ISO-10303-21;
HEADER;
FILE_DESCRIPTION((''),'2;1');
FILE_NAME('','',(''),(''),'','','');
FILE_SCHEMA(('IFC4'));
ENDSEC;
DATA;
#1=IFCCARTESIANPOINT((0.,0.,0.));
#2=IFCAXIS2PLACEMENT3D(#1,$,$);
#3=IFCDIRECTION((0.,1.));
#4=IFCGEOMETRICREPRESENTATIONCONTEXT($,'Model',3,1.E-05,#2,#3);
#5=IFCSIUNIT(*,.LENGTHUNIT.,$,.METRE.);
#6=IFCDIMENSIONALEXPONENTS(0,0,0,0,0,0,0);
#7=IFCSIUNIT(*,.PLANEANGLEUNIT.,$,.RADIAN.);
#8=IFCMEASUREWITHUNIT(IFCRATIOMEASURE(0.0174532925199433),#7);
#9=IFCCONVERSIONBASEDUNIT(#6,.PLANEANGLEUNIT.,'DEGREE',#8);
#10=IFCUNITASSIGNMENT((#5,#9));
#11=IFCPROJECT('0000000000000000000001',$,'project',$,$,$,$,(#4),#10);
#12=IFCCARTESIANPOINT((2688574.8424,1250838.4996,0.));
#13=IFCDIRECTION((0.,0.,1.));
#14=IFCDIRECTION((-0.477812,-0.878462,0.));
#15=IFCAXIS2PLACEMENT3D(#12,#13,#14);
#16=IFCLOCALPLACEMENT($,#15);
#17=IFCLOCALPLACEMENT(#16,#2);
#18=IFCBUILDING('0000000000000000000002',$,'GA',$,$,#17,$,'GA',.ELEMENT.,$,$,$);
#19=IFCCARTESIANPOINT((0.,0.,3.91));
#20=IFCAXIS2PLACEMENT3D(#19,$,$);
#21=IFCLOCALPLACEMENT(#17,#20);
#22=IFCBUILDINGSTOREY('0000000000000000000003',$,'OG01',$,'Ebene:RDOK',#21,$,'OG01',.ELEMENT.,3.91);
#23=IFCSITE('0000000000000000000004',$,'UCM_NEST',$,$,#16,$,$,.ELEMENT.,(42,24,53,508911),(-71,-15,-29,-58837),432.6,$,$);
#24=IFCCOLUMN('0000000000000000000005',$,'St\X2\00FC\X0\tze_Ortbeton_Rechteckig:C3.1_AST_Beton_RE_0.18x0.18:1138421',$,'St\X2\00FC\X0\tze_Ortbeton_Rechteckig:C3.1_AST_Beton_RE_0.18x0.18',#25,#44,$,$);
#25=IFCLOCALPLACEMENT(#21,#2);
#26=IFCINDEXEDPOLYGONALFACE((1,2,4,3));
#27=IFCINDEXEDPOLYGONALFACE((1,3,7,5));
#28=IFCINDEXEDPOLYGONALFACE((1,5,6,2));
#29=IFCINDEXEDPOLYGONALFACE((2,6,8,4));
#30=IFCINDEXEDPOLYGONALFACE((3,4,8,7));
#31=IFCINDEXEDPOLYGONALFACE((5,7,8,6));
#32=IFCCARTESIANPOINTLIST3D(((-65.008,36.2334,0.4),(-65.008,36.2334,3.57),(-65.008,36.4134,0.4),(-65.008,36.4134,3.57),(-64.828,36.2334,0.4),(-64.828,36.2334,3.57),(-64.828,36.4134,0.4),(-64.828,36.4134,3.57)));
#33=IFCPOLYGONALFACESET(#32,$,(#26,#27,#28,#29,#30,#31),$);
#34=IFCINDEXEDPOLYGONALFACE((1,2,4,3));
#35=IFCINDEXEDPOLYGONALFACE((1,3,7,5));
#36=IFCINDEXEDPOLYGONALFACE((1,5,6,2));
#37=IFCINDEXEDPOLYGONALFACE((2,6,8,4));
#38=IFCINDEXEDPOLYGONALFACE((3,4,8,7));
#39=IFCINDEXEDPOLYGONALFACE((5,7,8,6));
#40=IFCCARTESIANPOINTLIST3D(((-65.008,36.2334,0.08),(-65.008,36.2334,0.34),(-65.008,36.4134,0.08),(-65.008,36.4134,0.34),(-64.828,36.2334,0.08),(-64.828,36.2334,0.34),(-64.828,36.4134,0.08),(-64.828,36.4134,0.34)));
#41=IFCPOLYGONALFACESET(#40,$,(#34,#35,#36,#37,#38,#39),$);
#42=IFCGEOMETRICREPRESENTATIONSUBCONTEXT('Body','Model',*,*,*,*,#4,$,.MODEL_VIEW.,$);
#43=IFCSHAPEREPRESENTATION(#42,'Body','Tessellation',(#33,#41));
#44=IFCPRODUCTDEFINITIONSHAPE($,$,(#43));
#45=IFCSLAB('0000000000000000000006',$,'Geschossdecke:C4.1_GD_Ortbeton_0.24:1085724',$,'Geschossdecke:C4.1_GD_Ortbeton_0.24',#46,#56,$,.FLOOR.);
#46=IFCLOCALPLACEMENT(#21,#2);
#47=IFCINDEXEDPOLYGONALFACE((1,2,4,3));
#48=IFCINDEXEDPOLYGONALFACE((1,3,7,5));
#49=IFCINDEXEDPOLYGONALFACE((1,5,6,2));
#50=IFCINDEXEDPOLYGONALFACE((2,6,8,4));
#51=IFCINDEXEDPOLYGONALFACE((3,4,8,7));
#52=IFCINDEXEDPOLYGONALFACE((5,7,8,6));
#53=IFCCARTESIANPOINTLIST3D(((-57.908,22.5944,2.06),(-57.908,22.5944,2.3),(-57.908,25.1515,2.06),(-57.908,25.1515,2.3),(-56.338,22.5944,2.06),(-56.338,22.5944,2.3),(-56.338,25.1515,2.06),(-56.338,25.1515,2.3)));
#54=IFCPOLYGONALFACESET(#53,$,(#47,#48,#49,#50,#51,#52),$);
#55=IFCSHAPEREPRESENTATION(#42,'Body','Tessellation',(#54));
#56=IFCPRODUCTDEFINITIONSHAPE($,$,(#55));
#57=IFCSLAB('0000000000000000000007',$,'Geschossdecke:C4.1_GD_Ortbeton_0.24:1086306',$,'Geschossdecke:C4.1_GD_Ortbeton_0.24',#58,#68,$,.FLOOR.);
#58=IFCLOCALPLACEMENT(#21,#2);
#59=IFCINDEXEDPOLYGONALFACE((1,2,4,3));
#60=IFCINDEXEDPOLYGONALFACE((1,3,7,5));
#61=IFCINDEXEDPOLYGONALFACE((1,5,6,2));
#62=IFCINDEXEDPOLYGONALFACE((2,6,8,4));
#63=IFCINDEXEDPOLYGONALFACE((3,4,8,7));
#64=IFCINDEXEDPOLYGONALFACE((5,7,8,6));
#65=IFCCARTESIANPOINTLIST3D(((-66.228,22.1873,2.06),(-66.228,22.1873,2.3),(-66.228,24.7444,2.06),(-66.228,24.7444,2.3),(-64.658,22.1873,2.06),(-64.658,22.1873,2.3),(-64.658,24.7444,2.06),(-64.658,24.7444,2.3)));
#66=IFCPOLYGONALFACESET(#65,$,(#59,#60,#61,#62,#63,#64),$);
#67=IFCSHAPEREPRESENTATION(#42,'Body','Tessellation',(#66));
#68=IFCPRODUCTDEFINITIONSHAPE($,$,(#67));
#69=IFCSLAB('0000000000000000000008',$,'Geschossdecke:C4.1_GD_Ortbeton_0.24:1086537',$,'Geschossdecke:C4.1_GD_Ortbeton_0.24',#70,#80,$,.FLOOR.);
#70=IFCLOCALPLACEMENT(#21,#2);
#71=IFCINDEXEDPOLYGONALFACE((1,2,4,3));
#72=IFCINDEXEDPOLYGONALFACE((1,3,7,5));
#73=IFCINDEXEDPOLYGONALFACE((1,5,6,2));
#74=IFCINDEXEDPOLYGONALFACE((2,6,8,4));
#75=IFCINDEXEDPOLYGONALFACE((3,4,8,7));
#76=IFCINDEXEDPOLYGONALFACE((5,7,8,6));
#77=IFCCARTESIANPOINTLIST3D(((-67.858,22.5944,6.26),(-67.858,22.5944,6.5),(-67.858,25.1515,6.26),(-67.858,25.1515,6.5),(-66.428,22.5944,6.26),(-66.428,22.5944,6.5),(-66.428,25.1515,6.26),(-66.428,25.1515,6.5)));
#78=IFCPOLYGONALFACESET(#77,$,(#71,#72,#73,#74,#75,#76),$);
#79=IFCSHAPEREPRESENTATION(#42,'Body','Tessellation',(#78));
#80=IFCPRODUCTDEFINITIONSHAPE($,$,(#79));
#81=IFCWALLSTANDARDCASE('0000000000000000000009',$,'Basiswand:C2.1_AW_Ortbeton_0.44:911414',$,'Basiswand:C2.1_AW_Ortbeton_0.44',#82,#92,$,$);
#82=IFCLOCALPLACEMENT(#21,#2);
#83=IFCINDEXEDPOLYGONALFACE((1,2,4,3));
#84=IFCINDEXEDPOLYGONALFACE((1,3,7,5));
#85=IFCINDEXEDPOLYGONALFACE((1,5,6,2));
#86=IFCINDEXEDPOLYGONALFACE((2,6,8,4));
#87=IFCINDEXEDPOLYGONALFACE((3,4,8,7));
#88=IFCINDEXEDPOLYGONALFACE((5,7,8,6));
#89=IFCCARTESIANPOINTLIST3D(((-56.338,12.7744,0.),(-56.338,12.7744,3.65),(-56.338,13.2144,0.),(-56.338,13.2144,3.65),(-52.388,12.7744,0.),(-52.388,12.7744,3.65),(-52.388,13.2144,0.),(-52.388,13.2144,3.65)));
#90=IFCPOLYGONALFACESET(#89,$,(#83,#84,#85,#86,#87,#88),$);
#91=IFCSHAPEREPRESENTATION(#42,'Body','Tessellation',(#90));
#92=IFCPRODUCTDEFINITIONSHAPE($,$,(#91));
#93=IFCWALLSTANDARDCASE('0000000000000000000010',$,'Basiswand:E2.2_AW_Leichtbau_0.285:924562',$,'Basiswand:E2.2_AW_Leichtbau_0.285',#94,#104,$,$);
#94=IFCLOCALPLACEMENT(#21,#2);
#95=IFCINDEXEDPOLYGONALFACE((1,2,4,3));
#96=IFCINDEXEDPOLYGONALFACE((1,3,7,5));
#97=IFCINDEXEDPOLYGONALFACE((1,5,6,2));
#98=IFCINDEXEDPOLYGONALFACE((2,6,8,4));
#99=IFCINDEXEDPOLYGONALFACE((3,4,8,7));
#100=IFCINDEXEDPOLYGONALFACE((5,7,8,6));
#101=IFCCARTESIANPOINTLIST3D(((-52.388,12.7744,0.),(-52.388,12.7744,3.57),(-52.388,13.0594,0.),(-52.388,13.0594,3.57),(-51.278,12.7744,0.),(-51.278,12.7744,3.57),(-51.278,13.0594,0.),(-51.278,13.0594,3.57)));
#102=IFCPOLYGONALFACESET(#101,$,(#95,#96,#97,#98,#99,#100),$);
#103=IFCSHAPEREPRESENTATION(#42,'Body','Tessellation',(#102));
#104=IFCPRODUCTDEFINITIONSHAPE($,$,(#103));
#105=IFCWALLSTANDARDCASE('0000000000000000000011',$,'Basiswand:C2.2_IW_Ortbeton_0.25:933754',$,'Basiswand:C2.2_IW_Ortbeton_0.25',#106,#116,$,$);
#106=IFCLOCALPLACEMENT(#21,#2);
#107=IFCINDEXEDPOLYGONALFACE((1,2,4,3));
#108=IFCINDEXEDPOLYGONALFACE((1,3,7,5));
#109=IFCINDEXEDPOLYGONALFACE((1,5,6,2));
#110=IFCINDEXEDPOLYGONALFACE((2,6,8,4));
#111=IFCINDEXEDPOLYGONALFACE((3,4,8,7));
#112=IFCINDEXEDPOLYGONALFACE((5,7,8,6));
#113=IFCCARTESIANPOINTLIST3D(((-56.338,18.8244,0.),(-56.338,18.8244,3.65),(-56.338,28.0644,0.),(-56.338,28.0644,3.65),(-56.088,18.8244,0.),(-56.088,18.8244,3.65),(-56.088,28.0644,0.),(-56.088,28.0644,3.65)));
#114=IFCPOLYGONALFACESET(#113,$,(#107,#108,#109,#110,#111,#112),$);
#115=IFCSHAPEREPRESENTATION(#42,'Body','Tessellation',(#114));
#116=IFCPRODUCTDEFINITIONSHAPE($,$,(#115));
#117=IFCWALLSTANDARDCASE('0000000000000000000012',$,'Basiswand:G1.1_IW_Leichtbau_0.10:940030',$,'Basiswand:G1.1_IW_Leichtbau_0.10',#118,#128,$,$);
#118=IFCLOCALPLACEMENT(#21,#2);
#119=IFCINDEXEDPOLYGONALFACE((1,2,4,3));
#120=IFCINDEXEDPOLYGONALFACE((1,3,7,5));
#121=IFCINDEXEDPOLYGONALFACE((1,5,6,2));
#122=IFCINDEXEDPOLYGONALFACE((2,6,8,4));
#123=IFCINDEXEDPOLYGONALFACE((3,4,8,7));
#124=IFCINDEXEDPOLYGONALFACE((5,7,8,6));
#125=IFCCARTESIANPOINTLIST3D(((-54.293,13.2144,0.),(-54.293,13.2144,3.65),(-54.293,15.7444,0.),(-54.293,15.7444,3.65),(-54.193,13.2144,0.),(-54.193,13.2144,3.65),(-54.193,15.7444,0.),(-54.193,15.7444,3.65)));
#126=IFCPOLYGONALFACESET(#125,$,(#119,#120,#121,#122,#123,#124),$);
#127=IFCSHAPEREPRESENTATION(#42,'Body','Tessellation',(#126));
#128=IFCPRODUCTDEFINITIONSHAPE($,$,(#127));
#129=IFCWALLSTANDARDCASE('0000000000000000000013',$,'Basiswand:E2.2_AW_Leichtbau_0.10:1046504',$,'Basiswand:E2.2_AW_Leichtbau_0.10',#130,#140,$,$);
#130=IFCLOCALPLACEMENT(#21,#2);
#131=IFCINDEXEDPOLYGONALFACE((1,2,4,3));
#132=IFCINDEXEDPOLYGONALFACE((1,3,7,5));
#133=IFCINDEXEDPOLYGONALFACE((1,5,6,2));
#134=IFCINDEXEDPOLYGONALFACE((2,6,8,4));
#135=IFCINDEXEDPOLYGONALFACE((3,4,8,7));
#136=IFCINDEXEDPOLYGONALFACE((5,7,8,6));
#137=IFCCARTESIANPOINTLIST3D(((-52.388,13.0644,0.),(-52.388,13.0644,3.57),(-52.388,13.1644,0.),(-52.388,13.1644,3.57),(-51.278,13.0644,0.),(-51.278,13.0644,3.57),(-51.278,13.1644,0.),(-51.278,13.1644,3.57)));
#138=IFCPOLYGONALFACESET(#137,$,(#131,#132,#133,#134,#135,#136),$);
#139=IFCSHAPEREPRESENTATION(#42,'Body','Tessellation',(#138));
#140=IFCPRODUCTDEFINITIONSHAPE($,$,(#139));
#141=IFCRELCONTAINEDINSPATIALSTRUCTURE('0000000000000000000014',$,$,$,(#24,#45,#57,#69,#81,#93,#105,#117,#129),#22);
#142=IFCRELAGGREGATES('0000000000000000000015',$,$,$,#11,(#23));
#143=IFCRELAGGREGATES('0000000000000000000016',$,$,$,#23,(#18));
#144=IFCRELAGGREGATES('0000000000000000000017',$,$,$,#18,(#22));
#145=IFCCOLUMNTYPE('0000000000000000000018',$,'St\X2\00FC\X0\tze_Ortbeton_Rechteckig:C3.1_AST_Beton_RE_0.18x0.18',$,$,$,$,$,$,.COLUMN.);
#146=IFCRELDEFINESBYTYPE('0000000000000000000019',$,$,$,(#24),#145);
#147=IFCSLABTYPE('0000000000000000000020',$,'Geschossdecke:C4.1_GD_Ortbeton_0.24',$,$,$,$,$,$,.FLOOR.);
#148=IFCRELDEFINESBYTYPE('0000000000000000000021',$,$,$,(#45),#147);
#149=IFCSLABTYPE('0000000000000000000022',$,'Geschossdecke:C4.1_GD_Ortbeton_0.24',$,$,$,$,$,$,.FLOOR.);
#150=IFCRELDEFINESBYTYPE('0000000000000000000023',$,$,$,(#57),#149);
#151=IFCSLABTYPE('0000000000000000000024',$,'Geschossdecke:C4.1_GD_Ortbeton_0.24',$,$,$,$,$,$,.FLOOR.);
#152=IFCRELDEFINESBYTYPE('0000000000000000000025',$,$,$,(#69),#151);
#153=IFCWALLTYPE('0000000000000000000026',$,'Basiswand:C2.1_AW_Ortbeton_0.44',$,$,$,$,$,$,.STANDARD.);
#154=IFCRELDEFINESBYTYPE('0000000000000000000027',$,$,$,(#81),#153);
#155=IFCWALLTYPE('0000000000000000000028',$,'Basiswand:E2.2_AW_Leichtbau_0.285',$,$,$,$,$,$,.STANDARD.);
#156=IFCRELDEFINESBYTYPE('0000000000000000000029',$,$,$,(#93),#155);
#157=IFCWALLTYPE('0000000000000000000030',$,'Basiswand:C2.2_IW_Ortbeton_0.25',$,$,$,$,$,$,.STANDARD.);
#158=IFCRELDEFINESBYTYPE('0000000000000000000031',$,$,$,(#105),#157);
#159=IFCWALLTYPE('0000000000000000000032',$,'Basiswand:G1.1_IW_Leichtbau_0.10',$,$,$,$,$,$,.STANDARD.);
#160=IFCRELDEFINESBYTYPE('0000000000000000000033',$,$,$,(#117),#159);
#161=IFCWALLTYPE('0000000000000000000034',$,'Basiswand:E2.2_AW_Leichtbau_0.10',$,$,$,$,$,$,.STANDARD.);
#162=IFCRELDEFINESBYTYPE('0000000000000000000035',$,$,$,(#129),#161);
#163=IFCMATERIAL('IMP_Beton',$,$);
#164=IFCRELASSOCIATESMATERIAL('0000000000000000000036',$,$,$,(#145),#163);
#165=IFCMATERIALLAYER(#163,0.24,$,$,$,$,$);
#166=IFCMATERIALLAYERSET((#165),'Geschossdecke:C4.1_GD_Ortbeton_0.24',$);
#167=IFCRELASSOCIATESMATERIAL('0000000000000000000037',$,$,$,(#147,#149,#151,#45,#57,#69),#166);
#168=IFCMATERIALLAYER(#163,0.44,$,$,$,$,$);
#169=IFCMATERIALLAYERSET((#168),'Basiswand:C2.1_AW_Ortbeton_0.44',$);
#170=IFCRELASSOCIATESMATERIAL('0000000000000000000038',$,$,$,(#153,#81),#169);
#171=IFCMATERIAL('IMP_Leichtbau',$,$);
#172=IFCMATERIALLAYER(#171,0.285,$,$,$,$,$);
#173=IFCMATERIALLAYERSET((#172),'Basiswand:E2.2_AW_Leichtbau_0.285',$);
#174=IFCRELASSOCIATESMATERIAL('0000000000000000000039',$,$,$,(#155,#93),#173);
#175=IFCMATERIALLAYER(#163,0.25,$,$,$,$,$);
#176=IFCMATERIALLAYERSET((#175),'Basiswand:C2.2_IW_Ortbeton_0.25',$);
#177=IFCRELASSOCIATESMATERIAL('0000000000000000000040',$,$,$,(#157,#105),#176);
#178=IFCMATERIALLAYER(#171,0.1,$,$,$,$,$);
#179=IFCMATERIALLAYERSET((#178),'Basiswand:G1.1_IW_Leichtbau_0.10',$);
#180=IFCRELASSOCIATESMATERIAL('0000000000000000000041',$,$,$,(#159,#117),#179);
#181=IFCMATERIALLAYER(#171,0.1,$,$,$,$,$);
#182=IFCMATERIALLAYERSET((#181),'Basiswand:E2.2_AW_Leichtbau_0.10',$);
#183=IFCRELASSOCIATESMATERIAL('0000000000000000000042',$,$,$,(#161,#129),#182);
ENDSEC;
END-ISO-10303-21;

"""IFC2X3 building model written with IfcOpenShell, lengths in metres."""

from ifc_helpers import new_model, entity, si_unit, converted_unit, direction, frame, frame_2d, origin, origin_2d_with_axis, place, context, subcontext, project, spatial, polyline, rectangle, extrude, clip, bounded_halfspace, source, transform, mapped, material, layer, layer_set, layer_usage, type_object, type_shapes, element, save


model = new_model("IFC2X3")

# Units and contexts
model_context = context("Model", 3, precision=1e-05, world=origin(), true_north=direction((0.0, 1.0)))
body_context = subcontext(model_context, "Body", "Model", "MODEL_VIEW")
ifc_project = project(units=[si_unit("LENGTHUNIT", "METRE"), converted_unit("PLANEANGLEUNIT", "DEGREE", entity("IfcRatioMeasure", 0.0174532925199433), si_unit("PLANEANGLEUNIT", "RADIAN"), dimensions=[0, 0, 0, 0, 0, 0, 0])], contexts=[model_context])

# Site, building, storey
site_placement = place(None, frame((2688574.8424, 1250838.4996, 0.0), z_axis=(0.0, 0.0, 1.0), x_axis=(-0.477812, -0.878462, 0.0)))
site = spatial("IfcSite", under=ifc_project, at=site_placement, Name="UCM_NEST", CompositionType="ELEMENT", RefLatitude=(42, 24, 53, 508911), RefLongitude=(-71, -15, -29, -58837), RefElevation=432.6)
building_placement = place(site_placement, origin())
building = spatial("IfcBuilding", under=site, at=building_placement, Name="GA", LongName="GA", CompositionType="ELEMENT")
storey_placement = place(building_placement, frame((0.0, 0.0, 3.91)))
storey = spatial("IfcBuildingStorey", under=building, at=storey_placement, Name="OG01", ObjectType="Ebene:RDOK", LongName="OG01", CompositionType="ELEMENT", Elevation=3.91)

# Column
ifc_material_1 = material(Name="IMP_Beton")
column_type_1 = type_object("IfcColumnType", Name="Stütze_Ortbeton_Rechteckig:C3.1_AST_Beton_RE_0.18x0.18", PredefinedType="COLUMN", material=ifc_material_1)
shared_shape_1 = source(origin(), body_context, "Body", "SweptSolid", [
    extrude(rectangle(XDim=0.18, YDim=0.18, at=origin_2d_with_axis()), frame((-64.918, 36.3234, 4.31), z_axis=(0.0, 0.0, 1.0), x_axis=(0.0, -1.0, 0.0)), (0.0, 0.0, 1.0), 3.17),
    extrude(rectangle(XDim=0.18, YDim=0.18, at=origin_2d_with_axis()), frame((-64.918, 36.3234, 3.99), z_axis=(0.0, 0.0, 1.0), x_axis=(0.0, -1.0, 0.0)), (0.0, 0.0, 1.0), 0.26),
])
type_shapes(column_type_1, [shared_shape_1])
column_1_placement = place(storey_placement, frame((0.0, 0.0, -3.91)))
element("IfcColumn", 1, at=column_1_placement, inside=storey, type_object=column_type_1, Name="Stütze_Ortbeton_Rechteckig:C3.1_AST_Beton_RE_0.18x0.18:1138421", ObjectType="Stütze_Ortbeton_Rechteckig:C3.1_AST_Beton_RE_0.18x0.18", context=body_context, shape_type="MappedRepresentation", body=[
    mapped(shared_shape_1, transform((0.0, 0.0, 0.0), scale=1.0)),
])

# Slabs
ifc_layer_1 = layer(ifc_material_1, 0.24)
ifc_layer_set_1 = layer_set([ifc_layer_1], Name="Geschossdecke:C4.1_GD_Ortbeton_0.24")
ifc_layer_usage_1 = layer_usage(ifc_layer_set_1, "AXIS3", "POSITIVE", 0.0)
slab_type_1 = type_object("IfcSlabType", Name="Geschossdecke:C4.1_GD_Ortbeton_0.24", PredefinedType="FLOOR", material=ifc_layer_set_1)
slab_1_placement = place(storey_placement, origin())
element("IfcSlab", 2, at=slab_1_placement, inside=storey, type_object=slab_type_1, material=ifc_layer_usage_1, Name="Geschossdecke:C4.1_GD_Ortbeton_0.24:1085724", ObjectType="Geschossdecke:C4.1_GD_Ortbeton_0.24", PredefinedType="FLOOR", context=body_context, shape_type="SweptSolid", body=[
    extrude(rectangle(XDim=2.5571, YDim=1.57, at=frame_2d((0.0, 0.0), x_axis=(1.0, 0.0))), frame((-57.123, 23.873, 2.3), z_axis=(0.0, 0.0, -1.0), x_axis=(0.0, 1.0, 0.0)), (0.0, 0.0, 1.0), 0.24),
])
ifc_layer_usage_2 = layer_usage(ifc_layer_set_1, "AXIS3", "POSITIVE", 0.0)
slab_type_2 = type_object("IfcSlabType", Name="Geschossdecke:C4.1_GD_Ortbeton_0.24", PredefinedType="FLOOR", material=ifc_layer_set_1)
slab_2_placement = place(storey_placement, origin())
element("IfcSlab", 3, at=slab_2_placement, inside=storey, type_object=slab_type_2, material=ifc_layer_usage_2, Name="Geschossdecke:C4.1_GD_Ortbeton_0.24:1086306", ObjectType="Geschossdecke:C4.1_GD_Ortbeton_0.24", PredefinedType="FLOOR", context=body_context, shape_type="SweptSolid", body=[
    extrude(rectangle(XDim=2.5571, YDim=1.57, at=frame_2d((0.0, 0.0), x_axis=(1.0, 0.0))), frame((-65.443, 23.4659, 2.3), z_axis=(0.0, 0.0, -1.0), x_axis=(0.0, 1.0, 0.0)), (0.0, 0.0, 1.0), 0.24),
])
ifc_layer_usage_3 = layer_usage(ifc_layer_set_1, "AXIS3", "POSITIVE", 0.0)
slab_type_3 = type_object("IfcSlabType", Name="Geschossdecke:C4.1_GD_Ortbeton_0.24", PredefinedType="FLOOR", material=ifc_layer_set_1)
slab_3_placement = place(storey_placement, origin())
element("IfcSlab", 4, at=slab_3_placement, inside=storey, type_object=slab_type_3, material=ifc_layer_usage_3, Name="Geschossdecke:C4.1_GD_Ortbeton_0.24:1086537", ObjectType="Geschossdecke:C4.1_GD_Ortbeton_0.24", PredefinedType="FLOOR", context=body_context, shape_type="SweptSolid", body=[
    extrude(rectangle(XDim=2.5571, YDim=1.43, at=frame_2d((0.0, 0.0), x_axis=(1.0, 0.0))), frame((-67.143, 23.873, 6.5), z_axis=(0.0, 0.0, -1.0), x_axis=(0.0, 1.0, 0.0)), (0.0, 0.0, 1.0), 0.24),
])

# Walls
ifc_layer_2 = layer(ifc_material_1, 0.44)
ifc_layer_set_2 = layer_set([ifc_layer_2], Name="Basiswand:C2.1_AW_Ortbeton_0.44")
ifc_layer_usage_4 = layer_usage(ifc_layer_set_2, "AXIS2", "NEGATIVE", 0.22)
wall_type_1 = type_object("IfcWallType", Name="Basiswand:C2.1_AW_Ortbeton_0.44", PredefinedType="STANDARD", material=ifc_layer_set_2)
wall_1_placement = place(storey_placement, frame((-52.388, 12.9944, 0.0), z_axis=(0.0, 0.0, 1.0), x_axis=(-1.0, 0.0, 0.0)))
element("IfcWallStandardCase", 5, at=wall_1_placement, inside=storey, type_object=wall_type_1, material=ifc_layer_usage_4, Name="Basiswand:C2.1_AW_Ortbeton_0.44:911414", ObjectType="Basiswand:C2.1_AW_Ortbeton_0.44", context=body_context, shape_type="SweptSolid", body=[
    extrude(rectangle(XDim=3.95, YDim=0.44, at=frame_2d((1.975, 0.0), x_axis=(-1.0, 0.0))), origin(), (0.0, 0.0, 1.0), 3.65),
])
ifc_material_2 = material(Name="IMP_Leichtbau")
ifc_layer_3 = layer(ifc_material_2, 0.285)
ifc_layer_set_3 = layer_set([ifc_layer_3], Name="Basiswand:E2.2_AW_Leichtbau_0.285")
ifc_layer_usage_5 = layer_usage(ifc_layer_set_3, "AXIS2", "NEGATIVE", 0.1425)
wall_type_2 = type_object("IfcWallType", Name="Basiswand:E2.2_AW_Leichtbau_0.285", PredefinedType="STANDARD", material=ifc_layer_set_3)
wall_2_placement = place(storey_placement, frame((-51.278, 12.9169, 0.0), z_axis=(0.0, 0.0, 1.0), x_axis=(-1.0, 0.0, 0.0)))
element("IfcWallStandardCase", 6, at=wall_2_placement, inside=storey, type_object=wall_type_2, material=ifc_layer_usage_5, Name="Basiswand:E2.2_AW_Leichtbau_0.285:924562", ObjectType="Basiswand:E2.2_AW_Leichtbau_0.285", context=body_context, shape_type="Clipping", body=[
    clip(extrude(rectangle(XDim=1.11, YDim=0.285, at=frame_2d((0.555, 0.0), x_axis=(-1.0, 0.0))), origin(), (0.0, 0.0, 1.0), 3.57), bounded_halfspace(frame((0.0, -0.1425, 3.57), z_axis=(0.0, 0.0, -1.0), x_axis=(0.0, 1.0, 0.0)), True, frame((0.0, -0.1425, 3.57), z_axis=(0.0, 0.0, -1.0), x_axis=(0.0, 1.0, 0.0)), polyline([(0.0, 0.0), (0.285, 0.0), (0.285, 1.11), (0.0, 1.11), (0.0, 0.0)]))),
])

# Walls
ifc_layer_4 = layer(ifc_material_1, 0.25)
ifc_layer_set_4 = layer_set([ifc_layer_4], Name="Basiswand:C2.2_IW_Ortbeton_0.25")
ifc_layer_usage_6 = layer_usage(ifc_layer_set_4, "AXIS2", "NEGATIVE", 0.125)
wall_type_3 = type_object("IfcWallType", Name="Basiswand:C2.2_IW_Ortbeton_0.25", PredefinedType="STANDARD", material=ifc_layer_set_4)
wall_3_placement = place(storey_placement, frame((-56.213, 18.8244, 0.0), z_axis=(0.0, 0.0, 1.0), x_axis=(0.0, 1.0, 0.0)))
element("IfcWallStandardCase", 7, at=wall_3_placement, inside=storey, type_object=wall_type_3, material=ifc_layer_usage_6, Name="Basiswand:C2.2_IW_Ortbeton_0.25:933754", ObjectType="Basiswand:C2.2_IW_Ortbeton_0.25", context=body_context, shape_type="SweptSolid", body=[
    extrude(rectangle(XDim=9.24, YDim=0.25, at=frame_2d((4.62, 0.0), x_axis=(-1.0, 0.0))), origin(), (0.0, 0.0, 1.0), 3.65),
])
ifc_layer_5 = layer(ifc_material_2, 0.1)
ifc_layer_set_5 = layer_set([ifc_layer_5], Name="Basiswand:G1.1_IW_Leichtbau_0.10")
ifc_layer_usage_7 = layer_usage(ifc_layer_set_5, "AXIS2", "NEGATIVE", 0.05)
wall_type_4 = type_object("IfcWallType", Name="Basiswand:G1.1_IW_Leichtbau_0.10", PredefinedType="STANDARD", material=ifc_layer_set_5)
wall_4_placement = place(storey_placement, frame((-54.243, 15.7444, 0.0), z_axis=(0.0, 0.0, 1.0), x_axis=(0.0, -1.0, 0.0)))
element("IfcWallStandardCase", 8, at=wall_4_placement, inside=storey, type_object=wall_type_4, material=ifc_layer_usage_7, Name="Basiswand:G1.1_IW_Leichtbau_0.10:940030", ObjectType="Basiswand:G1.1_IW_Leichtbau_0.10", context=body_context, shape_type="SweptSolid", body=[
    extrude(rectangle(XDim=2.53, YDim=0.1, at=frame_2d((1.265, 0.0), x_axis=(-1.0, 0.0))), origin(), (0.0, 0.0, 1.0), 3.65),
])

# Wall
ifc_layer_6 = layer(ifc_material_2, 0.1)
ifc_layer_set_6 = layer_set([ifc_layer_6], Name="Basiswand:E2.2_AW_Leichtbau_0.10")
ifc_layer_usage_8 = layer_usage(ifc_layer_set_6, "AXIS2", "NEGATIVE", 0.05)
wall_type_5 = type_object("IfcWallType", Name="Basiswand:E2.2_AW_Leichtbau_0.10", PredefinedType="STANDARD", material=ifc_layer_set_6)
wall_5_placement = place(storey_placement, frame((-52.388, 13.1144, 0.0)))
element("IfcWallStandardCase", 9, at=wall_5_placement, inside=storey, type_object=wall_type_5, material=ifc_layer_usage_8, Name="Basiswand:E2.2_AW_Leichtbau_0.10:1046504", ObjectType="Basiswand:E2.2_AW_Leichtbau_0.10", context=body_context, shape_type="Clipping", body=[
    clip(extrude(rectangle(XDim=1.11, YDim=0.1, at=frame_2d((0.555, 0.0), x_axis=(-1.0, 0.0))), origin(), (0.0, 0.0, 1.0), 3.57), bounded_halfspace(frame((0.0, -0.05, 3.57), z_axis=(0.0, 0.0, -1.0), x_axis=(0.0, -1.0, 0.0)), True, frame((0.0, -0.05, 3.57), z_axis=(0.0, 0.0, -1.0), x_axis=(0.0, -1.0, 0.0)), polyline([(0.0, 0.0), (-0.1, 0.0), (-0.1, -1.11), (0.0, -1.11), (0.0, 0.0)]))),
])

save(model, "model.ifc")
